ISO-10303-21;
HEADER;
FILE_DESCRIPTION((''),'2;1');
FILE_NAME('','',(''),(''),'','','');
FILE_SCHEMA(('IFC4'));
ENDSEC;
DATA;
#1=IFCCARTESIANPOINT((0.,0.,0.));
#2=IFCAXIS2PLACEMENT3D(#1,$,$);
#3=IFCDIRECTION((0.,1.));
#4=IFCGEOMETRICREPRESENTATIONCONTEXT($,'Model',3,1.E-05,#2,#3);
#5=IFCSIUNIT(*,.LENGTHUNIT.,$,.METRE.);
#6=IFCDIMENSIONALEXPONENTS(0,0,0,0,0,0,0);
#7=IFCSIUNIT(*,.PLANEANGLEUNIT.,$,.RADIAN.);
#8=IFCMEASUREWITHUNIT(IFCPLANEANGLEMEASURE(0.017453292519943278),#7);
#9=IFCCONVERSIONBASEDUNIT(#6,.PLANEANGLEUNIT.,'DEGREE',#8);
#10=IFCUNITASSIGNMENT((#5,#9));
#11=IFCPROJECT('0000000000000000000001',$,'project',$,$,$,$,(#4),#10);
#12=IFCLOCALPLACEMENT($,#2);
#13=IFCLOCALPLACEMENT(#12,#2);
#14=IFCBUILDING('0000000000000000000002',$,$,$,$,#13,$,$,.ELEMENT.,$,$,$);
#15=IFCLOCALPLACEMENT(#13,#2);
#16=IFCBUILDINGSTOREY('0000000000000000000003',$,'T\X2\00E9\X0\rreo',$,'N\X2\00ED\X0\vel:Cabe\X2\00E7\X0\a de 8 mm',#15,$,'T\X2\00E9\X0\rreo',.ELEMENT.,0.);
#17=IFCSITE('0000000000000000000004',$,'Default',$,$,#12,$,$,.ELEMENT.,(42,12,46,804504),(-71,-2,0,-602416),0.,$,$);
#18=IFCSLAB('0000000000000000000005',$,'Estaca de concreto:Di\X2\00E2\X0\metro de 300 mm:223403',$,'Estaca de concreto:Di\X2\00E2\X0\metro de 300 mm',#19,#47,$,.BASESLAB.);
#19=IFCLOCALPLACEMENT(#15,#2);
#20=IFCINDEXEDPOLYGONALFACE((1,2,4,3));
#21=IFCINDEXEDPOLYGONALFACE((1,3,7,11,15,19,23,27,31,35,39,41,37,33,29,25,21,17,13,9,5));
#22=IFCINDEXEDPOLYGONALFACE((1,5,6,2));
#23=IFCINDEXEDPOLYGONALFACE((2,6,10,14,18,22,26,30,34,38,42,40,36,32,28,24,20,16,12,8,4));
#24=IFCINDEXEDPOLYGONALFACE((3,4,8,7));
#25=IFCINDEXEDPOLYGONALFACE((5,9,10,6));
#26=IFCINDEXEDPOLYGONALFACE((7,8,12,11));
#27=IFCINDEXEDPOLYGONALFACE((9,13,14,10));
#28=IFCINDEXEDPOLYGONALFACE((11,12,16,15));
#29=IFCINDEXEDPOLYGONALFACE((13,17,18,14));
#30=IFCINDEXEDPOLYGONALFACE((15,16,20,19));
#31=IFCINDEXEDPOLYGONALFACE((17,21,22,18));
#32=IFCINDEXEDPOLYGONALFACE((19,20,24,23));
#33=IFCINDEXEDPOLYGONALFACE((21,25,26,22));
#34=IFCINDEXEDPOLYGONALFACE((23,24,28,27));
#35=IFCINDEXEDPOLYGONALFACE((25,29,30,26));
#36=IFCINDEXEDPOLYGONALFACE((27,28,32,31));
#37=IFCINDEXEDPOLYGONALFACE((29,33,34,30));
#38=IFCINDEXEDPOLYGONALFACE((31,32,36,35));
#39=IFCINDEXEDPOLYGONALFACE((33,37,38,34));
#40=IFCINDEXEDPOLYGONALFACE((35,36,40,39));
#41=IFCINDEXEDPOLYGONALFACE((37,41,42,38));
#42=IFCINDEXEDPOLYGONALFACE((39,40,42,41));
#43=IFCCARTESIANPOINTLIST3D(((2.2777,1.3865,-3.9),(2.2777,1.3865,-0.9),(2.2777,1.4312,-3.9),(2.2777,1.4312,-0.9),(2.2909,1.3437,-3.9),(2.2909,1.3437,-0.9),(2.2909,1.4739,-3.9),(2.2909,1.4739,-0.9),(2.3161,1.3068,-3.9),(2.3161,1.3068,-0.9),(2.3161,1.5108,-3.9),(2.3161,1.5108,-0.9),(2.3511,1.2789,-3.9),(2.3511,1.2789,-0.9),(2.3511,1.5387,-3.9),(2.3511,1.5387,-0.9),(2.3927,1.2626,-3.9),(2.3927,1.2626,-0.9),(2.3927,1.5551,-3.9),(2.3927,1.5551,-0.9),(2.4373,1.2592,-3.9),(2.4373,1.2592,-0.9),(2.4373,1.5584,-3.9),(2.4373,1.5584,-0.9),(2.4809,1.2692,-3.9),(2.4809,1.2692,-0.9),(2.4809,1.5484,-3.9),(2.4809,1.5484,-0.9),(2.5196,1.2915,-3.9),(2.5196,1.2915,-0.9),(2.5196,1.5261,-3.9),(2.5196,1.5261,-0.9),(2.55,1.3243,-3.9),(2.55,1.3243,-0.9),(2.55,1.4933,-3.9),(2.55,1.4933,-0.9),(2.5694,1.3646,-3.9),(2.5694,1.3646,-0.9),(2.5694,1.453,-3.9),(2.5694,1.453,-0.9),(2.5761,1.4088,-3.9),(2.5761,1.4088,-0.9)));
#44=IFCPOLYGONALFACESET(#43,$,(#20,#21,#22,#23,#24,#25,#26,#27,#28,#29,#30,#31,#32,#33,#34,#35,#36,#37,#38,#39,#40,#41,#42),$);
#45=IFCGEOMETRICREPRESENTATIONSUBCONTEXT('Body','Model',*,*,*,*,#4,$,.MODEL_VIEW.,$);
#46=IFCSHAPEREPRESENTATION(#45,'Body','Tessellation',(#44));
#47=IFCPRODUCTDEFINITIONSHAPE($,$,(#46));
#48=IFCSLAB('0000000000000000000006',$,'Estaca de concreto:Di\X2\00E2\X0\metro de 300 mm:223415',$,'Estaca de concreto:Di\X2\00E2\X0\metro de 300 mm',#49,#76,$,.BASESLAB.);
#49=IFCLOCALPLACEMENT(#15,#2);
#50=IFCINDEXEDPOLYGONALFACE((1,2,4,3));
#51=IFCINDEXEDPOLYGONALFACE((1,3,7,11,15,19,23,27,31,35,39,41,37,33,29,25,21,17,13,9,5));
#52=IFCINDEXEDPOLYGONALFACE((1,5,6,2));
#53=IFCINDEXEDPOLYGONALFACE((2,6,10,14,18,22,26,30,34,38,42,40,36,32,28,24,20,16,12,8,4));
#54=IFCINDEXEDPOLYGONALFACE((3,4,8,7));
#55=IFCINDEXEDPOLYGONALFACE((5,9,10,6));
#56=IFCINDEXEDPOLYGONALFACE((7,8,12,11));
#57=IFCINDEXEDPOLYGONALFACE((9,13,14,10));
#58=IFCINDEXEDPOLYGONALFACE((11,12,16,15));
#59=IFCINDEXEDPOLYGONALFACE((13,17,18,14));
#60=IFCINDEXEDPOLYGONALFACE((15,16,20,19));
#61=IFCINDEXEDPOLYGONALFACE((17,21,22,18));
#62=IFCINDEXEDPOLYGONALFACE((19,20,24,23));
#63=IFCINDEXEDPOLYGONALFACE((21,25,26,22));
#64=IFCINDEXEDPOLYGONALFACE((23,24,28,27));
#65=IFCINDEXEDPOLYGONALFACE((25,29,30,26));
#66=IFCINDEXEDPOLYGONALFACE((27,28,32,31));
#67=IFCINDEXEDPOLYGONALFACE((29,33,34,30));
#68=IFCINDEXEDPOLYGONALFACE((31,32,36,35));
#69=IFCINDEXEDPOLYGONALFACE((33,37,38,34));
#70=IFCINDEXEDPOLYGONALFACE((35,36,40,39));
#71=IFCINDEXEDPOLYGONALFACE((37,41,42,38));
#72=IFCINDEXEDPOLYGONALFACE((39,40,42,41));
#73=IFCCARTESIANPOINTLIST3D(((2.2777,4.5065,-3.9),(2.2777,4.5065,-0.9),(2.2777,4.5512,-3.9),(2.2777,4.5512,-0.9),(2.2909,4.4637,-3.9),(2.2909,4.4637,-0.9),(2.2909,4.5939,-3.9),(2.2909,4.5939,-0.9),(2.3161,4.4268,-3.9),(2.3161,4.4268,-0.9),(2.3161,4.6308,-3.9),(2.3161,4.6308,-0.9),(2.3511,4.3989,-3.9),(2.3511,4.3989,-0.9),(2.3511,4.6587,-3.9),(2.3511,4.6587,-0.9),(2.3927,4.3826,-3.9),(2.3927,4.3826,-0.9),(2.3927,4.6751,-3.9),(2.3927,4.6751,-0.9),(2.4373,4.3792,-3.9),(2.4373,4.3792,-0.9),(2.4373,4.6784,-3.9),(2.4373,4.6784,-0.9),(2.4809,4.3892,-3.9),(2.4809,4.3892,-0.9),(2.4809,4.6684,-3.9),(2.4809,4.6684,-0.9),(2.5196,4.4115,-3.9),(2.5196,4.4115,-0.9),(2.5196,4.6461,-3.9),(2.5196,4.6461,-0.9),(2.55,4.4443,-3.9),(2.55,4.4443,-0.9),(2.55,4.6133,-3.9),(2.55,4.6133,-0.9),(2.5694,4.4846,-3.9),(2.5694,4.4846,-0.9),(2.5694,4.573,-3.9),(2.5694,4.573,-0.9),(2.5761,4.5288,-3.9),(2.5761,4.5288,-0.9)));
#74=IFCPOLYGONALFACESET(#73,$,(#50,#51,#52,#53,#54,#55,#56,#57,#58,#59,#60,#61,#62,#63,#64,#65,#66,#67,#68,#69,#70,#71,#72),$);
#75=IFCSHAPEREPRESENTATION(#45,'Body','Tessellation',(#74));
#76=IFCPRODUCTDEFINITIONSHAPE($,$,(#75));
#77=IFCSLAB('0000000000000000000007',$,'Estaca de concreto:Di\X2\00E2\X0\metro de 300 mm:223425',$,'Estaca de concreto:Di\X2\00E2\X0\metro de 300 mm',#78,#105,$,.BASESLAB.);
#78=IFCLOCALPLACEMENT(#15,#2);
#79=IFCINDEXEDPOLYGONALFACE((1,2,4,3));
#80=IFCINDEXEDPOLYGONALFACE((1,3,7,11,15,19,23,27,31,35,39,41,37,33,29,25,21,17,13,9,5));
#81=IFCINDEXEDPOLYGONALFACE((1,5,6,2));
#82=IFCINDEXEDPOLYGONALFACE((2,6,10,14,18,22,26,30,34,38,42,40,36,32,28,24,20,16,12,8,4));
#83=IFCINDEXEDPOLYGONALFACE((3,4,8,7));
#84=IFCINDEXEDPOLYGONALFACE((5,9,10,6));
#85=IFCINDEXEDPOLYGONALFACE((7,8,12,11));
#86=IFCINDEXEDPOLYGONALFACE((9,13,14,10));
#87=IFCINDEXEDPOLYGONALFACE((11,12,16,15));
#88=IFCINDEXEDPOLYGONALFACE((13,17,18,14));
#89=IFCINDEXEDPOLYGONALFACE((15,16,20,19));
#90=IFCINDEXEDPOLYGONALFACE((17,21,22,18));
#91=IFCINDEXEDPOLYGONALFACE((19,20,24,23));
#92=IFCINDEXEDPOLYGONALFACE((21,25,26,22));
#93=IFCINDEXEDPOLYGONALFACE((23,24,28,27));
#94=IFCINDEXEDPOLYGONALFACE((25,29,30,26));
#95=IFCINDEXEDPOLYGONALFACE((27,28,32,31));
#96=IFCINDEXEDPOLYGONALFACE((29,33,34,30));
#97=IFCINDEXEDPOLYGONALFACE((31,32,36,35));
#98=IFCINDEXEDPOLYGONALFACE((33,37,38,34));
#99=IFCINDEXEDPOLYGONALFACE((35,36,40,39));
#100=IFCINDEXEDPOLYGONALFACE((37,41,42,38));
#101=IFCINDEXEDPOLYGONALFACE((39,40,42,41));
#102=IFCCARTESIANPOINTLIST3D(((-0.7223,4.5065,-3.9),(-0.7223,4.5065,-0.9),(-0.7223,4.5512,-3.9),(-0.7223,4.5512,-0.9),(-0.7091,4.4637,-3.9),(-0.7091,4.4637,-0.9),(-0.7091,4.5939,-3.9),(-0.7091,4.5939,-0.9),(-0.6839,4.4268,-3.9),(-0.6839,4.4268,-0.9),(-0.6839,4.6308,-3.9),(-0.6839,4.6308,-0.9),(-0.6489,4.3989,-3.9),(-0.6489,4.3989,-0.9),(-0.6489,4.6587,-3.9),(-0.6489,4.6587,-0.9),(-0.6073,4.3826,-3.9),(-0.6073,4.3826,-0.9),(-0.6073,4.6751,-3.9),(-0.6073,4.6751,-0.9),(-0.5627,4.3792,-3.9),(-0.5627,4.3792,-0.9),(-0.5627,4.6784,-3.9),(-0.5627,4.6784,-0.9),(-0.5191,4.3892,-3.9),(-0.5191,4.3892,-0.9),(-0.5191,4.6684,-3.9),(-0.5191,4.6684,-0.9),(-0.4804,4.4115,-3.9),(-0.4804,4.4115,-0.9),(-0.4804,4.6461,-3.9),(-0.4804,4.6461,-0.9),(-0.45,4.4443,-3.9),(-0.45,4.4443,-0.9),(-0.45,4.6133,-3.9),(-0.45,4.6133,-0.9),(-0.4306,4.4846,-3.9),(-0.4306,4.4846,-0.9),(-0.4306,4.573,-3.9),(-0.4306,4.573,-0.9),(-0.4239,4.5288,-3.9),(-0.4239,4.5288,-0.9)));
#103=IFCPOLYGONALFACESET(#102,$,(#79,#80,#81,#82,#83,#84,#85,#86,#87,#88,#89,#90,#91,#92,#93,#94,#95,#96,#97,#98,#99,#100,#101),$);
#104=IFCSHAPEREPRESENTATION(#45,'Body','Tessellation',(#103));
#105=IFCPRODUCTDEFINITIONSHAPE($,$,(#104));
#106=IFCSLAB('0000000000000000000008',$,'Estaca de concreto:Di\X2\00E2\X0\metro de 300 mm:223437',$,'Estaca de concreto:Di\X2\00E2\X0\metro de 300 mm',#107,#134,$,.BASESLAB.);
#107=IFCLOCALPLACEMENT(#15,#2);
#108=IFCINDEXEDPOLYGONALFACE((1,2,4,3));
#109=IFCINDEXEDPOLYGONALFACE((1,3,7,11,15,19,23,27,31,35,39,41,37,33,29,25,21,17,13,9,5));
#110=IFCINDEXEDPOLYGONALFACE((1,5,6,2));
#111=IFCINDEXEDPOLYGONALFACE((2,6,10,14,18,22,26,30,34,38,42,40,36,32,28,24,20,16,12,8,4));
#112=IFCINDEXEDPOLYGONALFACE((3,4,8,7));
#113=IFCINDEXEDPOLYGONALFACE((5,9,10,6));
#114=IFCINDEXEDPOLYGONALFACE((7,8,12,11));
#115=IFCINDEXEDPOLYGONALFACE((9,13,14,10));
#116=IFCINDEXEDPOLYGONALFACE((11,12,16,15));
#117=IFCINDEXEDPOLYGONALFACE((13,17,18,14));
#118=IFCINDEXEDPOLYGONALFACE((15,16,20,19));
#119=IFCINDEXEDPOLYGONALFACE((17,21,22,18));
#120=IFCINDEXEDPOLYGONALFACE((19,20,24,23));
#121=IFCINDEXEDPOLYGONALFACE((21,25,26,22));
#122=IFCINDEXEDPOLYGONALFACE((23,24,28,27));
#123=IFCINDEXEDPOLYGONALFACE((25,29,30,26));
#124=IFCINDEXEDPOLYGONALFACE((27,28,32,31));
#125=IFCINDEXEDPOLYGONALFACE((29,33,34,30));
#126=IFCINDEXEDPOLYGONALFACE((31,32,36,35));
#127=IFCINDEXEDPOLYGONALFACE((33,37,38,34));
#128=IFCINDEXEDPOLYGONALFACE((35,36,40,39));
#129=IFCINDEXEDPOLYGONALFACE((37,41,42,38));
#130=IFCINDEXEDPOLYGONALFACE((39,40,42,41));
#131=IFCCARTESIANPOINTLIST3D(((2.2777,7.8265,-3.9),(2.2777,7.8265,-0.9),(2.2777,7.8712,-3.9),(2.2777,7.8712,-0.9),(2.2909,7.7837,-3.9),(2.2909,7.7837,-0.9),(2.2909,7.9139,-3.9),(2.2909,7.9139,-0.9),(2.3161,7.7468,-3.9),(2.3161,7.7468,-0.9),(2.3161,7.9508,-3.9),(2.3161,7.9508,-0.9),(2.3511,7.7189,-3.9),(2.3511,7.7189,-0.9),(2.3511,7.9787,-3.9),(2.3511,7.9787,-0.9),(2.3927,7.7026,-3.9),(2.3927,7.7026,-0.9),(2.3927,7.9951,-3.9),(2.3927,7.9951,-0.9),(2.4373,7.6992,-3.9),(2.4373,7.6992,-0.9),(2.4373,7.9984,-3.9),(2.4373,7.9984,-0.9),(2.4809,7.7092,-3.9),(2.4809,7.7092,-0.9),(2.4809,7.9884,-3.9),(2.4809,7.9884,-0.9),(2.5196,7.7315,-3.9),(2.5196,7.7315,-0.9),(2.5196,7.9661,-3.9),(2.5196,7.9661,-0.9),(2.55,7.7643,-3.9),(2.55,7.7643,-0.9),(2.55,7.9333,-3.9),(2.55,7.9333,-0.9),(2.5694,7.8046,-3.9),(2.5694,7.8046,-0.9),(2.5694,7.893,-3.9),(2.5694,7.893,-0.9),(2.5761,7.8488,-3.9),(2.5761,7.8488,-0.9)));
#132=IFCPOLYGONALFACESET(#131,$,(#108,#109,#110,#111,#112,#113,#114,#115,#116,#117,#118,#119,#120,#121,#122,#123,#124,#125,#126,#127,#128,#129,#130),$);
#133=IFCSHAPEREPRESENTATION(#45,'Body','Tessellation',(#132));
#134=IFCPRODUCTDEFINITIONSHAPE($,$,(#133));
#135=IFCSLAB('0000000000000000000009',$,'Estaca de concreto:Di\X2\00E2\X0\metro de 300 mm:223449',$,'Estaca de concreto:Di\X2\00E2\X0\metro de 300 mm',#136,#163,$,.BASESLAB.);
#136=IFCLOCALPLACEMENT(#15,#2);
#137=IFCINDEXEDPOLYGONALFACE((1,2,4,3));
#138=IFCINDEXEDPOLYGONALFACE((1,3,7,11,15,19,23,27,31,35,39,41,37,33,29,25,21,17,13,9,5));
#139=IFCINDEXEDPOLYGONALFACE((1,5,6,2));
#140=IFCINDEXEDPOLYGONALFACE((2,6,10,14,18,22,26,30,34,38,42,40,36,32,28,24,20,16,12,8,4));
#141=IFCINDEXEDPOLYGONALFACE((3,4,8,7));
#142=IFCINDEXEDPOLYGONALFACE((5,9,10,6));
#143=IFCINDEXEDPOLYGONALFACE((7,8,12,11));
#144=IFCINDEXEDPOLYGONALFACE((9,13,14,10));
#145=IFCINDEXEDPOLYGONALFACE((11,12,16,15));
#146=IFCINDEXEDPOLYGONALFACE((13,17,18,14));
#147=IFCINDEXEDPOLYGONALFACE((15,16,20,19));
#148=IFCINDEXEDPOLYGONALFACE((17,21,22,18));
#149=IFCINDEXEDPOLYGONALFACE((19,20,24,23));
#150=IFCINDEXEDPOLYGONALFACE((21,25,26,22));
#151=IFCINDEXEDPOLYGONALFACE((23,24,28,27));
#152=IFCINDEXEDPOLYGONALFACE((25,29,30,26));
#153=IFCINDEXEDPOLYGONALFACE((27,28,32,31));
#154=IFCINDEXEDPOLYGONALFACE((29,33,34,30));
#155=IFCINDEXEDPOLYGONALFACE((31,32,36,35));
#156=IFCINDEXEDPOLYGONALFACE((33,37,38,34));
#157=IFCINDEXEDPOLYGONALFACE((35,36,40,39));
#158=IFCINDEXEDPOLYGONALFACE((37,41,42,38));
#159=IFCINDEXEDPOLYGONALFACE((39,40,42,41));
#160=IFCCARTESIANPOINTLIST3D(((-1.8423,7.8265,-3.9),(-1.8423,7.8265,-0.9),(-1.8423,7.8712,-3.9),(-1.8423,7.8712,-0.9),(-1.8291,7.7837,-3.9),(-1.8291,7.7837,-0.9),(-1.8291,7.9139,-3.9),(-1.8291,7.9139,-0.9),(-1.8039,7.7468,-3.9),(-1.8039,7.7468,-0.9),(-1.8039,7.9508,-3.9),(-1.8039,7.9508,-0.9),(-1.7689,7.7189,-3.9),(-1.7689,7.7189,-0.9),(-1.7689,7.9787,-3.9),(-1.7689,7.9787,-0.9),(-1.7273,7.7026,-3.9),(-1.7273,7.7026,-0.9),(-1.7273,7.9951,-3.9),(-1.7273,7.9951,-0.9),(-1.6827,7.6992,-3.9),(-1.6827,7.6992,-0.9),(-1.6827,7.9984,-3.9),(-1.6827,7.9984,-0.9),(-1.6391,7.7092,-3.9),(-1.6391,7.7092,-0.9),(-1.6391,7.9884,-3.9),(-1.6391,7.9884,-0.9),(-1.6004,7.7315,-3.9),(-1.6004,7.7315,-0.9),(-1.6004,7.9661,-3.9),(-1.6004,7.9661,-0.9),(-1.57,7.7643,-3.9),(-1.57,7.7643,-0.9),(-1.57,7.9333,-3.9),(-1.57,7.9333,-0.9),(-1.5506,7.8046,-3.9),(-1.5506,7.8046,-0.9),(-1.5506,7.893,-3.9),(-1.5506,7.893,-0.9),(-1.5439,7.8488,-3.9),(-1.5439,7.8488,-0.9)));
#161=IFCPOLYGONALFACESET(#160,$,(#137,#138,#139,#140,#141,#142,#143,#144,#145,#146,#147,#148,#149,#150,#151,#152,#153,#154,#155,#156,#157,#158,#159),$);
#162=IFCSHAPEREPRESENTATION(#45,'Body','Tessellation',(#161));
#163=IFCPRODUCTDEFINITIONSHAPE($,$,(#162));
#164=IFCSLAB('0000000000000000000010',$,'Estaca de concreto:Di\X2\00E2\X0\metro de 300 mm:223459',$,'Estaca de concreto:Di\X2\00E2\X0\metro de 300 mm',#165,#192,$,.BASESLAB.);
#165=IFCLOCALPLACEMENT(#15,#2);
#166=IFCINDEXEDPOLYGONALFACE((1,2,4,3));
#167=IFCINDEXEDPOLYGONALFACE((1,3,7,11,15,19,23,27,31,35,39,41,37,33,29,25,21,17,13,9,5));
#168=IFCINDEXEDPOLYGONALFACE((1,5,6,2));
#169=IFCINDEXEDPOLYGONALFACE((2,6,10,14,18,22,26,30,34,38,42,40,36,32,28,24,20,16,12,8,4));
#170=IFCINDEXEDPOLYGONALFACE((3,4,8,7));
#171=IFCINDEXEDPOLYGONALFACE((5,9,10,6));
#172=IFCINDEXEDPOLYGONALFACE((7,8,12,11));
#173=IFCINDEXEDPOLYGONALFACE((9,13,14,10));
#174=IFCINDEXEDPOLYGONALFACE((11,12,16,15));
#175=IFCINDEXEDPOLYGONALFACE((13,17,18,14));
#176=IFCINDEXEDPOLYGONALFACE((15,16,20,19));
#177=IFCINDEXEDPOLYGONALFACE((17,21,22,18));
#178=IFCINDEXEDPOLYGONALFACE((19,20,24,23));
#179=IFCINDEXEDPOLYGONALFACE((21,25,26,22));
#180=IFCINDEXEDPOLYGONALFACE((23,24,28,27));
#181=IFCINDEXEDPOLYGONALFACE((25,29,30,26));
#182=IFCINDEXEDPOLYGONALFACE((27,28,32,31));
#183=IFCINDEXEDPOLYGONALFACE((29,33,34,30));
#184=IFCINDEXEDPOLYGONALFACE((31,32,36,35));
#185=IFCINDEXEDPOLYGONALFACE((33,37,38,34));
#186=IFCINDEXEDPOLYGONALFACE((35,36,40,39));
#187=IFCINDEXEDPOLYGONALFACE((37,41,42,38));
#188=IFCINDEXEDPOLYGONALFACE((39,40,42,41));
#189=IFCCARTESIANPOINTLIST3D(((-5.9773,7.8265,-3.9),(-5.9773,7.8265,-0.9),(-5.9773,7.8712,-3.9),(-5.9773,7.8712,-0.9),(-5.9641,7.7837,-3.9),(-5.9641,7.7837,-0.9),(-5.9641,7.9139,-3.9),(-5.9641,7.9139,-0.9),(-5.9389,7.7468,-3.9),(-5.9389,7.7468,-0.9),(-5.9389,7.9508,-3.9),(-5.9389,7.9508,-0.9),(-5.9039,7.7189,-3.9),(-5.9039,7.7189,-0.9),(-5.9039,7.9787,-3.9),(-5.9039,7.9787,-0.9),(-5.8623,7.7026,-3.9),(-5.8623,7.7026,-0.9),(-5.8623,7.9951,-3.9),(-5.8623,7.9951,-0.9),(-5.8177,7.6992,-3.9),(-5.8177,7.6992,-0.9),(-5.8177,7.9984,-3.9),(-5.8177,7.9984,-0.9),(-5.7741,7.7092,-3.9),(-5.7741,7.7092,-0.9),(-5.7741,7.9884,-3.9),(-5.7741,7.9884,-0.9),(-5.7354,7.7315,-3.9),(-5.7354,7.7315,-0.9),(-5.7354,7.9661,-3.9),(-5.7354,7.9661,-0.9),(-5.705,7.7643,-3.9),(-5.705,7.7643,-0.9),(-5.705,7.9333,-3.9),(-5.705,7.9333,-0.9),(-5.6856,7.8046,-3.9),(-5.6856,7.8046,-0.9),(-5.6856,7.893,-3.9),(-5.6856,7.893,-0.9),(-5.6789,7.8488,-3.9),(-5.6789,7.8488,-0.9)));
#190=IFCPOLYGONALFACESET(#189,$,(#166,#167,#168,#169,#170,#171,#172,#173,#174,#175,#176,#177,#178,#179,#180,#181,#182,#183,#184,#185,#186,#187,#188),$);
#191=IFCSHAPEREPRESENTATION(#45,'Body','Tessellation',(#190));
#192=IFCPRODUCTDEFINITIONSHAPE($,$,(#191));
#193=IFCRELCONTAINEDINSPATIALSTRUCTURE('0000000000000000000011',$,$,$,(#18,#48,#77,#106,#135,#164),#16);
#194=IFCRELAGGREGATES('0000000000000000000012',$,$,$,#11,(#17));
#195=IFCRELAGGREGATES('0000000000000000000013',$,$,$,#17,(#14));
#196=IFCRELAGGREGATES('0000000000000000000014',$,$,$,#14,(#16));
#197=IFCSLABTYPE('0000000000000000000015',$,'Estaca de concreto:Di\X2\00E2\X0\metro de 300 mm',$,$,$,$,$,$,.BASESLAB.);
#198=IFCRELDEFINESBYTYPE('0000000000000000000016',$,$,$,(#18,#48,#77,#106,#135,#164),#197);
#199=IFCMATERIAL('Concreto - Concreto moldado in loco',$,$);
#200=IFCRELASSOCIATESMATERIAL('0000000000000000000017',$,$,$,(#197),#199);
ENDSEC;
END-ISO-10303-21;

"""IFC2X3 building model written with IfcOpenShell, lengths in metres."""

from ifc_helpers import new_model, entity, si_unit, converted_unit, direction, frame, frame_2d, origin, origin_2d_with_axis, place, context, subcontext, project, spatial, circle, extrude, material, type_object, element, save


model = new_model("IFC2X3")

# Units and contexts
model_context = context("Model", 3, precision=1e-05, world=origin(), true_north=direction((0.0, 1.0)))
body_context = subcontext(model_context, "Body", "Model", "MODEL_VIEW")
ifc_project = project(units=[si_unit("LENGTHUNIT", "METRE"), converted_unit("PLANEANGLEUNIT", "DEGREE", entity("IfcPlaneAngleMeasure", 0.017453292519943278), si_unit("PLANEANGLEUNIT", "RADIAN"), dimensions=[0, 0, 0, 0, 0, 0, 0])], contexts=[model_context])

# Site, building, storey
site_placement = place(None, origin())
site = spatial("IfcSite", under=ifc_project, at=site_placement, Name="Default", CompositionType="ELEMENT", RefLatitude=(42, 12, 46, 804504), RefLongitude=(-71, -2, 0, -602416), RefElevation=0.0)
building_placement = place(site_placement, origin())
building = spatial("IfcBuilding", under=site, at=building_placement, CompositionType="ELEMENT")
storey_placement = place(building_placement, origin())
storey = spatial("IfcBuildingStorey", under=building, at=storey_placement, Name="Térreo", ObjectType="Nível:Cabeça de 8 mm", LongName="Térreo", CompositionType="ELEMENT", Elevation=0.0)

# Slabs
ifc_material_1 = material(Name="Concreto - Concreto moldado in loco")
slab_type_1 = type_object("IfcSlabType", Name="Estaca de concreto:Diâmetro de 300 mm", PredefinedType="BASESLAB", material=ifc_material_1)
slab_1_placement = place(storey_placement, origin())
element("IfcSlab", 1, at=slab_1_placement, inside=storey, type_object=slab_type_1, Name="Estaca de concreto:Diâmetro de 300 mm:223403", ObjectType="Estaca de concreto:Diâmetro de 300 mm", PredefinedType="BASESLAB", context=body_context, shape_type="SweptSolid", body=[
    extrude(circle(Radius=0.15, at=frame_2d((0.0, 0.0), x_axis=(1.0, 0.0))), frame((2.4261, 1.4088, -3.9)), (0.0, 0.0, 1.0), 3.0),
])
slab_2_placement = place(storey_placement, origin())
element("IfcSlab", 2, at=slab_2_placement, inside=storey, type_object=slab_type_1, Name="Estaca de concreto:Diâmetro de 300 mm:223415", ObjectType="Estaca de concreto:Diâmetro de 300 mm", PredefinedType="BASESLAB", context=body_context, shape_type="SweptSolid", body=[
    extrude(circle(Radius=0.15, at=frame_2d((0.0, 0.0), x_axis=(1.0, 0.0))), frame((2.4261, 4.5288, -3.9)), (0.0, 0.0, 1.0), 3.0),
])
slab_3_placement = place(storey_placement, origin())
element("IfcSlab", 3, at=slab_3_placement, inside=storey, type_object=slab_type_1, Name="Estaca de concreto:Diâmetro de 300 mm:223425", ObjectType="Estaca de concreto:Diâmetro de 300 mm", PredefinedType="BASESLAB", context=body_context, shape_type="SweptSolid", body=[
    extrude(circle(Radius=0.15, at=frame_2d((0.0, 0.0), x_axis=(1.0, 0.0))), frame((-0.5739, 4.5288, -3.9)), (0.0, 0.0, 1.0), 3.0),
])
slab_4_placement = place(storey_placement, origin())
element("IfcSlab", 4, at=slab_4_placement, inside=storey, type_object=slab_type_1, Name="Estaca de concreto:Diâmetro de 300 mm:223437", ObjectType="Estaca de concreto:Diâmetro de 300 mm", PredefinedType="BASESLAB", context=body_context, shape_type="SweptSolid", body=[
    extrude(circle(Radius=0.15, at=frame_2d((0.0, 0.0), x_axis=(1.0, 0.0))), frame((2.4261, 7.8488, -3.9)), (0.0, 0.0, 1.0), 3.0),
])
slab_5_placement = place(storey_placement, origin())
element("IfcSlab", 5, at=slab_5_placement, inside=storey, type_object=slab_type_1, Name="Estaca de concreto:Diâmetro de 300 mm:223449", ObjectType="Estaca de concreto:Diâmetro de 300 mm", PredefinedType="BASESLAB", context=body_context, shape_type="SweptSolid", body=[
    extrude(circle(Radius=0.15, at=origin_2d_with_axis()), frame((-1.6939, 7.8488, -3.9)), (0.0, 0.0, 1.0), 3.0),
])
slab_6_placement = place(storey_placement, origin())
element("IfcSlab", 6, at=slab_6_placement, inside=storey, type_object=slab_type_1, Name="Estaca de concreto:Diâmetro de 300 mm:223459", ObjectType="Estaca de concreto:Diâmetro de 300 mm", PredefinedType="BASESLAB", context=body_context, shape_type="SweptSolid", body=[
    extrude(circle(Radius=0.15, at=origin_2d_with_axis()), frame((-5.8289, 7.8488, -3.9)), (0.0, 0.0, 1.0), 3.0),
])

save(model, "model.ifc")
